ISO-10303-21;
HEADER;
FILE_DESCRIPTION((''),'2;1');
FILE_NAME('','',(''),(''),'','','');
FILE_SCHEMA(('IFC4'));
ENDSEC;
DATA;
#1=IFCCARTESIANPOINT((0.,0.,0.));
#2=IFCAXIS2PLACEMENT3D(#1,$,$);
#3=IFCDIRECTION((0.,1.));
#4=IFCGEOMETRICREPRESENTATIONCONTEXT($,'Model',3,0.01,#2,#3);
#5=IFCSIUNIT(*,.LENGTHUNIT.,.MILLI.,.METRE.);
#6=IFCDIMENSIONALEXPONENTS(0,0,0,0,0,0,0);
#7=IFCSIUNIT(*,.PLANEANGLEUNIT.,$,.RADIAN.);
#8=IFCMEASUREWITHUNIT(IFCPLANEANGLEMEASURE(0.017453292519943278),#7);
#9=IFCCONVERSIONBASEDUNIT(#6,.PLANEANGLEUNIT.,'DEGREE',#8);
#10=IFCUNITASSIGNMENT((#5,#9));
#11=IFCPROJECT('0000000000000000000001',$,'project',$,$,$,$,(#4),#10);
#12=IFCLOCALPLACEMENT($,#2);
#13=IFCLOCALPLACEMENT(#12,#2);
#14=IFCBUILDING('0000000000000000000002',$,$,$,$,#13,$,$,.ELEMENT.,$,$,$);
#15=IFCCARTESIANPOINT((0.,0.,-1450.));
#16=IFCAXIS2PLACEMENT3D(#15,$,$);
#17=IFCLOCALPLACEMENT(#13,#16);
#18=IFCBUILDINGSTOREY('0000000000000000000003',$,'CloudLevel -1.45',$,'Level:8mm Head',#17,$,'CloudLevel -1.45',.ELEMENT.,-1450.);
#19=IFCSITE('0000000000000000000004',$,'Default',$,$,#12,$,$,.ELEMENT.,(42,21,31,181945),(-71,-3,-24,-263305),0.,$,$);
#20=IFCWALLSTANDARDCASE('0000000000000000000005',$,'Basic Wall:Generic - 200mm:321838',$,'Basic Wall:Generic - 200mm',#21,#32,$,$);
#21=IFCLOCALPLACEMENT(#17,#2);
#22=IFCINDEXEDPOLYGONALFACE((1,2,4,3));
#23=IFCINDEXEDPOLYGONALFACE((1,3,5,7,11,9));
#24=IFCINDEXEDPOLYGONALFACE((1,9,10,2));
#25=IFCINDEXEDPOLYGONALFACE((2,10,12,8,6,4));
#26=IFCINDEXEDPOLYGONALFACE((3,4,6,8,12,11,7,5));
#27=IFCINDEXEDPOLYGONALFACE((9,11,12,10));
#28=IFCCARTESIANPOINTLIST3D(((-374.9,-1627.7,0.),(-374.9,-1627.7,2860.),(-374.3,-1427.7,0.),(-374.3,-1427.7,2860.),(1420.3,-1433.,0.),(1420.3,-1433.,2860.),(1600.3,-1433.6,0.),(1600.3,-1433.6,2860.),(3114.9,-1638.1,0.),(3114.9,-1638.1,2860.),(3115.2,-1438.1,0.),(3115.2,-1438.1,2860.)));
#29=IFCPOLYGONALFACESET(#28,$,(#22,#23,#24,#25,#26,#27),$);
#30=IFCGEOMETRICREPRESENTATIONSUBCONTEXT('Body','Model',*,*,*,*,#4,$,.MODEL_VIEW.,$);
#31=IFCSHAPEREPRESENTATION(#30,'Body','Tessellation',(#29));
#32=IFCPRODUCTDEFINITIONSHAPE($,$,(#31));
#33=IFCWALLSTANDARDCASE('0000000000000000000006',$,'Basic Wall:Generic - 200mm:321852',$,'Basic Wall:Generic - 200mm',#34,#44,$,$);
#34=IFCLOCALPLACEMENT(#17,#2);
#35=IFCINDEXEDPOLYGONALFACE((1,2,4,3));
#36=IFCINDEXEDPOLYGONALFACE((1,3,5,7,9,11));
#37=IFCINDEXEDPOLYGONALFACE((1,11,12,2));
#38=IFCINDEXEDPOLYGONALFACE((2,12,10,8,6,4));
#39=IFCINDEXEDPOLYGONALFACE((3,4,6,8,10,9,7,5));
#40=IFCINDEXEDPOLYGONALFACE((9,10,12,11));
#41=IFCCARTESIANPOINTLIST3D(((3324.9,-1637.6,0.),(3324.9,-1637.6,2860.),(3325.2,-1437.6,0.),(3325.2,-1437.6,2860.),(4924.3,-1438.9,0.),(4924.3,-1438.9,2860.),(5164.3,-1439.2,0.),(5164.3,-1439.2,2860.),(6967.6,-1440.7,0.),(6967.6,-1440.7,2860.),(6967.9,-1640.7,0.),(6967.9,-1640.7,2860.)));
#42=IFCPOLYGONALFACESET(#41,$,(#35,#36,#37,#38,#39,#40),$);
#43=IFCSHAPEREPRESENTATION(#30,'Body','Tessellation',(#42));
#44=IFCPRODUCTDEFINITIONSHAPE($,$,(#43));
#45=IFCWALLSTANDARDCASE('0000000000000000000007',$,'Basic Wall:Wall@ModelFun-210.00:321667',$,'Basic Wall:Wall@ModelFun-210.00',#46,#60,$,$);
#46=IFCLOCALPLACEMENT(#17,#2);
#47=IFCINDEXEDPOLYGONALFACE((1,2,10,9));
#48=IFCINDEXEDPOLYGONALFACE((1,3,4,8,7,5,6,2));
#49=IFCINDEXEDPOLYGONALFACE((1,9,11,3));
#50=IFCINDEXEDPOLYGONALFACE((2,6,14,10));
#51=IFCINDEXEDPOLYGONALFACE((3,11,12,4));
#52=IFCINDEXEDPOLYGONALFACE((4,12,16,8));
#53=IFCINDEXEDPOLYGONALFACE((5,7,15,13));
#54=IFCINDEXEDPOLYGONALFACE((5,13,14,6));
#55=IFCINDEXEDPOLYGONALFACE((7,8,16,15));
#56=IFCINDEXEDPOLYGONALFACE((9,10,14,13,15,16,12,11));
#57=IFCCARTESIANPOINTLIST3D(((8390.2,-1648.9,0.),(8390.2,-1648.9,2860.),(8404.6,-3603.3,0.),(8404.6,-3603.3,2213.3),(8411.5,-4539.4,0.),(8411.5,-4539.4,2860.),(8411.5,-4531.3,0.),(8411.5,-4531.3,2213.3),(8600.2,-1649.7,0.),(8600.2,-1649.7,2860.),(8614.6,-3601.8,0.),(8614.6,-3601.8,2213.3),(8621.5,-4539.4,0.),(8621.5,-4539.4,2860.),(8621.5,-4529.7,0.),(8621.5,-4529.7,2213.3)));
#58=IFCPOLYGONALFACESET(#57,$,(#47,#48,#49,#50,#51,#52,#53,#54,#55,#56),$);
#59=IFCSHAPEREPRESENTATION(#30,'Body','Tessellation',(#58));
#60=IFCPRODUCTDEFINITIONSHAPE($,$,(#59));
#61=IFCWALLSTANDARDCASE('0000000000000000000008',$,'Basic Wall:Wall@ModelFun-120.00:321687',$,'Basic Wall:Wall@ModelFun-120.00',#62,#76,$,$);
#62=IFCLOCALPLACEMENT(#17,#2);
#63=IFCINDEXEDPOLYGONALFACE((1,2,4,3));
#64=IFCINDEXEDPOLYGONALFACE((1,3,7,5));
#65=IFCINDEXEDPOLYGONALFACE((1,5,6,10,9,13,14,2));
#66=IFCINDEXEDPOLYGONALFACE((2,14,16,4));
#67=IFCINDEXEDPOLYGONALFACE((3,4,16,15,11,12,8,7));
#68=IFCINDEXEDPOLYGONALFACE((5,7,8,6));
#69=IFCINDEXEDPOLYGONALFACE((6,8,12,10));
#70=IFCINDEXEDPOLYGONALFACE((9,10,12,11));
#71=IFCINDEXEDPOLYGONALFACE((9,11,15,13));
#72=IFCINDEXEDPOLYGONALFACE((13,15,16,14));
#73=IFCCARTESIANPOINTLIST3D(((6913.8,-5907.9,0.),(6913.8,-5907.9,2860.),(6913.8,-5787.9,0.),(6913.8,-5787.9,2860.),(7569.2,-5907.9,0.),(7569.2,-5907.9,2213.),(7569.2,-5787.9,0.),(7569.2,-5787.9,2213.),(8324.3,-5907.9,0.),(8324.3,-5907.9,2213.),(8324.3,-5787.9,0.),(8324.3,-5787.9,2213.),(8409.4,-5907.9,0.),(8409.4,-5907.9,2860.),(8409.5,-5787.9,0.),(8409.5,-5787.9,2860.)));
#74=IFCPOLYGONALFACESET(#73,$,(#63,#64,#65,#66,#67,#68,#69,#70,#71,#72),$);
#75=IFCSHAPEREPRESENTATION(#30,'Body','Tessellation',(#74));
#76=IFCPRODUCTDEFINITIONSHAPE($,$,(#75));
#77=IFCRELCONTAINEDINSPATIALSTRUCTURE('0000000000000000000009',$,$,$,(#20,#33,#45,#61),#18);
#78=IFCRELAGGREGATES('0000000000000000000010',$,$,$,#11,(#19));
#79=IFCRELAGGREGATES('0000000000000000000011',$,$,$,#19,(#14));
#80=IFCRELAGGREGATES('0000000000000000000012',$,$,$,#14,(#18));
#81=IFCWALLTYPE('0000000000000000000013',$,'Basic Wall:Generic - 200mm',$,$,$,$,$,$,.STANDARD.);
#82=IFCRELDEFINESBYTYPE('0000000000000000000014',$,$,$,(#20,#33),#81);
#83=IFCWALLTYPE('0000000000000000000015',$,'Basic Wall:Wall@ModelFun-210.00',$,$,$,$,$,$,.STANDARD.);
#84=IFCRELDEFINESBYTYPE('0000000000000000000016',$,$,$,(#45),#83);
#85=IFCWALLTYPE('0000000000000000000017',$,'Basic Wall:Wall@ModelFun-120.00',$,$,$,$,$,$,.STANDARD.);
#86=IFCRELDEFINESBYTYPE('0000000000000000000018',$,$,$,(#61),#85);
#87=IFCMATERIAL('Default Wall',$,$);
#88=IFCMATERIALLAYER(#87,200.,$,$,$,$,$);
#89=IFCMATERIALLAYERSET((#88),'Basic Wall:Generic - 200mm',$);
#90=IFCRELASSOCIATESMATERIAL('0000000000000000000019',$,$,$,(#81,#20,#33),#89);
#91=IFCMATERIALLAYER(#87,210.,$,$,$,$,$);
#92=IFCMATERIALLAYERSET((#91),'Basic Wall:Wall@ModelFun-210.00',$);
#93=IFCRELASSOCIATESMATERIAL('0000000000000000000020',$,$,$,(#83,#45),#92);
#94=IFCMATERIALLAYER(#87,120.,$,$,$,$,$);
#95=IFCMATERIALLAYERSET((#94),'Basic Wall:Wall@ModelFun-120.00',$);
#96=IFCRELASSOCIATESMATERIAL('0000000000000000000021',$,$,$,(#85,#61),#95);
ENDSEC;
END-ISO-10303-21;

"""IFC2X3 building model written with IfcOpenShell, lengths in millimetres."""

from ifc_helpers import new_model, entity, si_unit, converted_unit, direction, frame, frame_2d, origin, place, context, subcontext, project, spatial, polyline, rectangle, outline, extrude, material, layer, layer_set, layer_usage, type_object, element, save


model = new_model("IFC2X3")

# Units and contexts
model_context = context("Model", 3, precision=0.01, world=origin(), true_north=direction((0.0, 1.0)))
body_context = subcontext(model_context, "Body", "Model", "MODEL_VIEW")
ifc_project = project(units=[si_unit("LENGTHUNIT", "METRE", prefix="MILLI"), converted_unit("PLANEANGLEUNIT", "DEGREE", entity("IfcPlaneAngleMeasure", 0.017453292519943278), si_unit("PLANEANGLEUNIT", "RADIAN"), dimensions=[0, 0, 0, 0, 0, 0, 0])], contexts=[model_context])

# Site, building, storey
site_placement = place(None, origin())
site = spatial("IfcSite", under=ifc_project, at=site_placement, Name="Default", CompositionType="ELEMENT", RefLatitude=(42, 21, 31, 181945), RefLongitude=(-71, -3, -24, -263305), RefElevation=0.0)
building_placement = place(site_placement, origin())
building = spatial("IfcBuilding", under=site, at=building_placement, CompositionType="ELEMENT")
storey_placement = place(building_placement, frame((0.0, 0.0, -1450.0)))
storey = spatial("IfcBuildingStorey", under=building, at=storey_placement, Name="CloudLevel -1.45", ObjectType="Level:8mm Head", LongName="CloudLevel -1.45", CompositionType="ELEMENT", Elevation=-1450.0)

# Shared definitions
ifc_material_1 = material(Name="Default Wall")

# Shared definitions
ifc_layer_1 = layer(ifc_material_1, 200.0)
ifc_layer_set_1 = layer_set([ifc_layer_1], Name="Basic Wall:Generic - 200mm")
ifc_layer_usage_1 = layer_usage(ifc_layer_set_1, "AXIS2", "NEGATIVE", 100.0)
wall_type_1 = type_object("IfcWallType", Name="Basic Wall:Generic - 200mm", PredefinedType="STANDARD", material=ifc_layer_set_1)

# Walls
wall_1_placement = place(storey_placement, frame((3115.2, -1538.1, 0.0), z_axis=(0.0, 0.0, 1.0), x_axis=(-0.999996, 0.002971, 0.0)))
element("IfcWallStandardCase", 1, at=wall_1_placement, inside=storey, type_object=wall_type_1, material=ifc_layer_usage_1, Name="Basic Wall:Generic - 200mm:321838", ObjectType="Basic Wall:Generic - 200mm", context=body_context, shape_type="SweptSolid", body=[
    extrude(outline(polyline([(3489.8, -100.0), (3489.8, 100.0), (0.0, 100.0), (0.2, -100.0), (1515.1, -100.0), (1695.1, -100.0), (3489.8, -100.0)])), origin(), (0.0, 0.0, 1.0), 2860.0),
])
wall_2_placement = place(storey_placement, frame((6968.0, -1540.7, 0.0), z_axis=(0.0, 0.0, 1.0), x_axis=(-1.0, 0.000842, 0.0)))
element("IfcWallStandardCase", 2, at=wall_2_placement, inside=storey, type_object=wall_type_1, material=ifc_layer_usage_1, Name="Basic Wall:Generic - 200mm:321852", ObjectType="Basic Wall:Generic - 200mm", context=body_context, shape_type="SweptSolid", body=[
    extrude(outline(polyline([(3642.8, -100.0), (3643.0, 100.0), (0.0, 100.0), (0.4, -100.0), (1803.8, -100.0), (2043.8, -100.0), (3642.8, -100.0)])), origin(), (0.0, 0.0, 1.0), 2860.0),
])

# Walls, openings
ifc_layer_2 = layer(ifc_material_1, 210.0)
ifc_layer_set_2 = layer_set([ifc_layer_2], Name="Basic Wall:Wall@ModelFun-210.00")
ifc_layer_usage_2 = layer_usage(ifc_layer_set_2, "AXIS2", "NEGATIVE", 105.0)
wall_type_2 = type_object("IfcWallType", Name="Basic Wall:Wall@ModelFun-210.00", PredefinedType="STANDARD", material=ifc_layer_set_2)
wall_3_placement = place(storey_placement, frame((8516.5, -4540.2, 0.0), z_axis=(0.0, 0.0, 1.0), x_axis=(-0.007369, 0.999973, 0.0)))
wall_3 = element("IfcWallStandardCase", 3, at=wall_3_placement, inside=storey, type_object=wall_type_2, material=ifc_layer_usage_2, Name="Basic Wall:Wall@ModelFun-210.00:321667", ObjectType="Basic Wall:Wall@ModelFun-210.00", context=body_context, shape_type="SweptSolid", body=[
    extrude(outline(polyline([(0.0, -105.0), (2889.7, -105.0), (2890.9, 1.2), (2892.1, 105.0), (1.5, 105.0), (0.0, -105.0)])), origin(), (0.0, 0.0, 1.0), 2860.0),
])
opening_1_placement = place(wall_3_placement, frame((9.7, -105.0, 0.0)))
element("IfcOpeningElement", 4, at=opening_1_placement, cuts=wall_3, ObjectType="Opening", context=body_context, shape_type="SweptSolid", body=[
    extrude(rectangle(XDim=928.0, YDim=2213.3, at=frame_2d((1106.7, 464.0), x_axis=(0.0, 1.0))), frame((0.0, 0.0, 0.0), z_axis=(0.0, 1.0, 0.0), x_axis=(0.0, 0.0, 1.0)), (0.0, 0.0, 1.0), 210.0),
])
ifc_layer_3 = layer(ifc_material_1, 120.0)
ifc_layer_set_3 = layer_set([ifc_layer_3], Name="Basic Wall:Wall@ModelFun-120.00")
ifc_layer_usage_3 = layer_usage(ifc_layer_set_3, "AXIS2", "NEGATIVE", 60.0)
wall_type_3 = type_object("IfcWallType", Name="Basic Wall:Wall@ModelFun-120.00", PredefinedType="STANDARD", material=ifc_layer_set_3)
wall_4_placement = place(storey_placement, frame((8409.5, -5847.9, 0.0), z_axis=(0.0, 0.0, 1.0), x_axis=(-1.0, 0.0, 0.0)))
wall_4 = element("IfcWallStandardCase", 5, at=wall_4_placement, inside=storey, type_object=wall_type_3, material=ifc_layer_usage_3, Name="Basic Wall:Wall@ModelFun-120.00:321687", ObjectType="Basic Wall:Wall@ModelFun-120.00", context=body_context, shape_type="SweptSolid", body=[
    extrude(outline(polyline([(0.0, -60.0), (1495.7, -60.0), (1495.7, 60.0), (0.2, 60.0), (0.0, -60.0)])), origin(), (0.0, 0.0, 1.0), 2860.0),
])
opening_2_placement = place(wall_4_placement, frame((85.3, -60.0, 0.0)))
element("IfcOpeningElement", 6, at=opening_2_placement, cuts=wall_4, ObjectType="Opening", context=body_context, shape_type="SweptSolid", body=[
    extrude(rectangle(XDim=755.1, YDim=2213.0, at=frame_2d((1106.5, 377.6), x_axis=(0.0, 1.0))), frame((0.0, 0.0, 0.0), z_axis=(0.0, 1.0, 0.0), x_axis=(0.0, 0.0, 1.0)), (0.0, 0.0, 1.0), 120.0),
])

save(model, "model.ifc")
